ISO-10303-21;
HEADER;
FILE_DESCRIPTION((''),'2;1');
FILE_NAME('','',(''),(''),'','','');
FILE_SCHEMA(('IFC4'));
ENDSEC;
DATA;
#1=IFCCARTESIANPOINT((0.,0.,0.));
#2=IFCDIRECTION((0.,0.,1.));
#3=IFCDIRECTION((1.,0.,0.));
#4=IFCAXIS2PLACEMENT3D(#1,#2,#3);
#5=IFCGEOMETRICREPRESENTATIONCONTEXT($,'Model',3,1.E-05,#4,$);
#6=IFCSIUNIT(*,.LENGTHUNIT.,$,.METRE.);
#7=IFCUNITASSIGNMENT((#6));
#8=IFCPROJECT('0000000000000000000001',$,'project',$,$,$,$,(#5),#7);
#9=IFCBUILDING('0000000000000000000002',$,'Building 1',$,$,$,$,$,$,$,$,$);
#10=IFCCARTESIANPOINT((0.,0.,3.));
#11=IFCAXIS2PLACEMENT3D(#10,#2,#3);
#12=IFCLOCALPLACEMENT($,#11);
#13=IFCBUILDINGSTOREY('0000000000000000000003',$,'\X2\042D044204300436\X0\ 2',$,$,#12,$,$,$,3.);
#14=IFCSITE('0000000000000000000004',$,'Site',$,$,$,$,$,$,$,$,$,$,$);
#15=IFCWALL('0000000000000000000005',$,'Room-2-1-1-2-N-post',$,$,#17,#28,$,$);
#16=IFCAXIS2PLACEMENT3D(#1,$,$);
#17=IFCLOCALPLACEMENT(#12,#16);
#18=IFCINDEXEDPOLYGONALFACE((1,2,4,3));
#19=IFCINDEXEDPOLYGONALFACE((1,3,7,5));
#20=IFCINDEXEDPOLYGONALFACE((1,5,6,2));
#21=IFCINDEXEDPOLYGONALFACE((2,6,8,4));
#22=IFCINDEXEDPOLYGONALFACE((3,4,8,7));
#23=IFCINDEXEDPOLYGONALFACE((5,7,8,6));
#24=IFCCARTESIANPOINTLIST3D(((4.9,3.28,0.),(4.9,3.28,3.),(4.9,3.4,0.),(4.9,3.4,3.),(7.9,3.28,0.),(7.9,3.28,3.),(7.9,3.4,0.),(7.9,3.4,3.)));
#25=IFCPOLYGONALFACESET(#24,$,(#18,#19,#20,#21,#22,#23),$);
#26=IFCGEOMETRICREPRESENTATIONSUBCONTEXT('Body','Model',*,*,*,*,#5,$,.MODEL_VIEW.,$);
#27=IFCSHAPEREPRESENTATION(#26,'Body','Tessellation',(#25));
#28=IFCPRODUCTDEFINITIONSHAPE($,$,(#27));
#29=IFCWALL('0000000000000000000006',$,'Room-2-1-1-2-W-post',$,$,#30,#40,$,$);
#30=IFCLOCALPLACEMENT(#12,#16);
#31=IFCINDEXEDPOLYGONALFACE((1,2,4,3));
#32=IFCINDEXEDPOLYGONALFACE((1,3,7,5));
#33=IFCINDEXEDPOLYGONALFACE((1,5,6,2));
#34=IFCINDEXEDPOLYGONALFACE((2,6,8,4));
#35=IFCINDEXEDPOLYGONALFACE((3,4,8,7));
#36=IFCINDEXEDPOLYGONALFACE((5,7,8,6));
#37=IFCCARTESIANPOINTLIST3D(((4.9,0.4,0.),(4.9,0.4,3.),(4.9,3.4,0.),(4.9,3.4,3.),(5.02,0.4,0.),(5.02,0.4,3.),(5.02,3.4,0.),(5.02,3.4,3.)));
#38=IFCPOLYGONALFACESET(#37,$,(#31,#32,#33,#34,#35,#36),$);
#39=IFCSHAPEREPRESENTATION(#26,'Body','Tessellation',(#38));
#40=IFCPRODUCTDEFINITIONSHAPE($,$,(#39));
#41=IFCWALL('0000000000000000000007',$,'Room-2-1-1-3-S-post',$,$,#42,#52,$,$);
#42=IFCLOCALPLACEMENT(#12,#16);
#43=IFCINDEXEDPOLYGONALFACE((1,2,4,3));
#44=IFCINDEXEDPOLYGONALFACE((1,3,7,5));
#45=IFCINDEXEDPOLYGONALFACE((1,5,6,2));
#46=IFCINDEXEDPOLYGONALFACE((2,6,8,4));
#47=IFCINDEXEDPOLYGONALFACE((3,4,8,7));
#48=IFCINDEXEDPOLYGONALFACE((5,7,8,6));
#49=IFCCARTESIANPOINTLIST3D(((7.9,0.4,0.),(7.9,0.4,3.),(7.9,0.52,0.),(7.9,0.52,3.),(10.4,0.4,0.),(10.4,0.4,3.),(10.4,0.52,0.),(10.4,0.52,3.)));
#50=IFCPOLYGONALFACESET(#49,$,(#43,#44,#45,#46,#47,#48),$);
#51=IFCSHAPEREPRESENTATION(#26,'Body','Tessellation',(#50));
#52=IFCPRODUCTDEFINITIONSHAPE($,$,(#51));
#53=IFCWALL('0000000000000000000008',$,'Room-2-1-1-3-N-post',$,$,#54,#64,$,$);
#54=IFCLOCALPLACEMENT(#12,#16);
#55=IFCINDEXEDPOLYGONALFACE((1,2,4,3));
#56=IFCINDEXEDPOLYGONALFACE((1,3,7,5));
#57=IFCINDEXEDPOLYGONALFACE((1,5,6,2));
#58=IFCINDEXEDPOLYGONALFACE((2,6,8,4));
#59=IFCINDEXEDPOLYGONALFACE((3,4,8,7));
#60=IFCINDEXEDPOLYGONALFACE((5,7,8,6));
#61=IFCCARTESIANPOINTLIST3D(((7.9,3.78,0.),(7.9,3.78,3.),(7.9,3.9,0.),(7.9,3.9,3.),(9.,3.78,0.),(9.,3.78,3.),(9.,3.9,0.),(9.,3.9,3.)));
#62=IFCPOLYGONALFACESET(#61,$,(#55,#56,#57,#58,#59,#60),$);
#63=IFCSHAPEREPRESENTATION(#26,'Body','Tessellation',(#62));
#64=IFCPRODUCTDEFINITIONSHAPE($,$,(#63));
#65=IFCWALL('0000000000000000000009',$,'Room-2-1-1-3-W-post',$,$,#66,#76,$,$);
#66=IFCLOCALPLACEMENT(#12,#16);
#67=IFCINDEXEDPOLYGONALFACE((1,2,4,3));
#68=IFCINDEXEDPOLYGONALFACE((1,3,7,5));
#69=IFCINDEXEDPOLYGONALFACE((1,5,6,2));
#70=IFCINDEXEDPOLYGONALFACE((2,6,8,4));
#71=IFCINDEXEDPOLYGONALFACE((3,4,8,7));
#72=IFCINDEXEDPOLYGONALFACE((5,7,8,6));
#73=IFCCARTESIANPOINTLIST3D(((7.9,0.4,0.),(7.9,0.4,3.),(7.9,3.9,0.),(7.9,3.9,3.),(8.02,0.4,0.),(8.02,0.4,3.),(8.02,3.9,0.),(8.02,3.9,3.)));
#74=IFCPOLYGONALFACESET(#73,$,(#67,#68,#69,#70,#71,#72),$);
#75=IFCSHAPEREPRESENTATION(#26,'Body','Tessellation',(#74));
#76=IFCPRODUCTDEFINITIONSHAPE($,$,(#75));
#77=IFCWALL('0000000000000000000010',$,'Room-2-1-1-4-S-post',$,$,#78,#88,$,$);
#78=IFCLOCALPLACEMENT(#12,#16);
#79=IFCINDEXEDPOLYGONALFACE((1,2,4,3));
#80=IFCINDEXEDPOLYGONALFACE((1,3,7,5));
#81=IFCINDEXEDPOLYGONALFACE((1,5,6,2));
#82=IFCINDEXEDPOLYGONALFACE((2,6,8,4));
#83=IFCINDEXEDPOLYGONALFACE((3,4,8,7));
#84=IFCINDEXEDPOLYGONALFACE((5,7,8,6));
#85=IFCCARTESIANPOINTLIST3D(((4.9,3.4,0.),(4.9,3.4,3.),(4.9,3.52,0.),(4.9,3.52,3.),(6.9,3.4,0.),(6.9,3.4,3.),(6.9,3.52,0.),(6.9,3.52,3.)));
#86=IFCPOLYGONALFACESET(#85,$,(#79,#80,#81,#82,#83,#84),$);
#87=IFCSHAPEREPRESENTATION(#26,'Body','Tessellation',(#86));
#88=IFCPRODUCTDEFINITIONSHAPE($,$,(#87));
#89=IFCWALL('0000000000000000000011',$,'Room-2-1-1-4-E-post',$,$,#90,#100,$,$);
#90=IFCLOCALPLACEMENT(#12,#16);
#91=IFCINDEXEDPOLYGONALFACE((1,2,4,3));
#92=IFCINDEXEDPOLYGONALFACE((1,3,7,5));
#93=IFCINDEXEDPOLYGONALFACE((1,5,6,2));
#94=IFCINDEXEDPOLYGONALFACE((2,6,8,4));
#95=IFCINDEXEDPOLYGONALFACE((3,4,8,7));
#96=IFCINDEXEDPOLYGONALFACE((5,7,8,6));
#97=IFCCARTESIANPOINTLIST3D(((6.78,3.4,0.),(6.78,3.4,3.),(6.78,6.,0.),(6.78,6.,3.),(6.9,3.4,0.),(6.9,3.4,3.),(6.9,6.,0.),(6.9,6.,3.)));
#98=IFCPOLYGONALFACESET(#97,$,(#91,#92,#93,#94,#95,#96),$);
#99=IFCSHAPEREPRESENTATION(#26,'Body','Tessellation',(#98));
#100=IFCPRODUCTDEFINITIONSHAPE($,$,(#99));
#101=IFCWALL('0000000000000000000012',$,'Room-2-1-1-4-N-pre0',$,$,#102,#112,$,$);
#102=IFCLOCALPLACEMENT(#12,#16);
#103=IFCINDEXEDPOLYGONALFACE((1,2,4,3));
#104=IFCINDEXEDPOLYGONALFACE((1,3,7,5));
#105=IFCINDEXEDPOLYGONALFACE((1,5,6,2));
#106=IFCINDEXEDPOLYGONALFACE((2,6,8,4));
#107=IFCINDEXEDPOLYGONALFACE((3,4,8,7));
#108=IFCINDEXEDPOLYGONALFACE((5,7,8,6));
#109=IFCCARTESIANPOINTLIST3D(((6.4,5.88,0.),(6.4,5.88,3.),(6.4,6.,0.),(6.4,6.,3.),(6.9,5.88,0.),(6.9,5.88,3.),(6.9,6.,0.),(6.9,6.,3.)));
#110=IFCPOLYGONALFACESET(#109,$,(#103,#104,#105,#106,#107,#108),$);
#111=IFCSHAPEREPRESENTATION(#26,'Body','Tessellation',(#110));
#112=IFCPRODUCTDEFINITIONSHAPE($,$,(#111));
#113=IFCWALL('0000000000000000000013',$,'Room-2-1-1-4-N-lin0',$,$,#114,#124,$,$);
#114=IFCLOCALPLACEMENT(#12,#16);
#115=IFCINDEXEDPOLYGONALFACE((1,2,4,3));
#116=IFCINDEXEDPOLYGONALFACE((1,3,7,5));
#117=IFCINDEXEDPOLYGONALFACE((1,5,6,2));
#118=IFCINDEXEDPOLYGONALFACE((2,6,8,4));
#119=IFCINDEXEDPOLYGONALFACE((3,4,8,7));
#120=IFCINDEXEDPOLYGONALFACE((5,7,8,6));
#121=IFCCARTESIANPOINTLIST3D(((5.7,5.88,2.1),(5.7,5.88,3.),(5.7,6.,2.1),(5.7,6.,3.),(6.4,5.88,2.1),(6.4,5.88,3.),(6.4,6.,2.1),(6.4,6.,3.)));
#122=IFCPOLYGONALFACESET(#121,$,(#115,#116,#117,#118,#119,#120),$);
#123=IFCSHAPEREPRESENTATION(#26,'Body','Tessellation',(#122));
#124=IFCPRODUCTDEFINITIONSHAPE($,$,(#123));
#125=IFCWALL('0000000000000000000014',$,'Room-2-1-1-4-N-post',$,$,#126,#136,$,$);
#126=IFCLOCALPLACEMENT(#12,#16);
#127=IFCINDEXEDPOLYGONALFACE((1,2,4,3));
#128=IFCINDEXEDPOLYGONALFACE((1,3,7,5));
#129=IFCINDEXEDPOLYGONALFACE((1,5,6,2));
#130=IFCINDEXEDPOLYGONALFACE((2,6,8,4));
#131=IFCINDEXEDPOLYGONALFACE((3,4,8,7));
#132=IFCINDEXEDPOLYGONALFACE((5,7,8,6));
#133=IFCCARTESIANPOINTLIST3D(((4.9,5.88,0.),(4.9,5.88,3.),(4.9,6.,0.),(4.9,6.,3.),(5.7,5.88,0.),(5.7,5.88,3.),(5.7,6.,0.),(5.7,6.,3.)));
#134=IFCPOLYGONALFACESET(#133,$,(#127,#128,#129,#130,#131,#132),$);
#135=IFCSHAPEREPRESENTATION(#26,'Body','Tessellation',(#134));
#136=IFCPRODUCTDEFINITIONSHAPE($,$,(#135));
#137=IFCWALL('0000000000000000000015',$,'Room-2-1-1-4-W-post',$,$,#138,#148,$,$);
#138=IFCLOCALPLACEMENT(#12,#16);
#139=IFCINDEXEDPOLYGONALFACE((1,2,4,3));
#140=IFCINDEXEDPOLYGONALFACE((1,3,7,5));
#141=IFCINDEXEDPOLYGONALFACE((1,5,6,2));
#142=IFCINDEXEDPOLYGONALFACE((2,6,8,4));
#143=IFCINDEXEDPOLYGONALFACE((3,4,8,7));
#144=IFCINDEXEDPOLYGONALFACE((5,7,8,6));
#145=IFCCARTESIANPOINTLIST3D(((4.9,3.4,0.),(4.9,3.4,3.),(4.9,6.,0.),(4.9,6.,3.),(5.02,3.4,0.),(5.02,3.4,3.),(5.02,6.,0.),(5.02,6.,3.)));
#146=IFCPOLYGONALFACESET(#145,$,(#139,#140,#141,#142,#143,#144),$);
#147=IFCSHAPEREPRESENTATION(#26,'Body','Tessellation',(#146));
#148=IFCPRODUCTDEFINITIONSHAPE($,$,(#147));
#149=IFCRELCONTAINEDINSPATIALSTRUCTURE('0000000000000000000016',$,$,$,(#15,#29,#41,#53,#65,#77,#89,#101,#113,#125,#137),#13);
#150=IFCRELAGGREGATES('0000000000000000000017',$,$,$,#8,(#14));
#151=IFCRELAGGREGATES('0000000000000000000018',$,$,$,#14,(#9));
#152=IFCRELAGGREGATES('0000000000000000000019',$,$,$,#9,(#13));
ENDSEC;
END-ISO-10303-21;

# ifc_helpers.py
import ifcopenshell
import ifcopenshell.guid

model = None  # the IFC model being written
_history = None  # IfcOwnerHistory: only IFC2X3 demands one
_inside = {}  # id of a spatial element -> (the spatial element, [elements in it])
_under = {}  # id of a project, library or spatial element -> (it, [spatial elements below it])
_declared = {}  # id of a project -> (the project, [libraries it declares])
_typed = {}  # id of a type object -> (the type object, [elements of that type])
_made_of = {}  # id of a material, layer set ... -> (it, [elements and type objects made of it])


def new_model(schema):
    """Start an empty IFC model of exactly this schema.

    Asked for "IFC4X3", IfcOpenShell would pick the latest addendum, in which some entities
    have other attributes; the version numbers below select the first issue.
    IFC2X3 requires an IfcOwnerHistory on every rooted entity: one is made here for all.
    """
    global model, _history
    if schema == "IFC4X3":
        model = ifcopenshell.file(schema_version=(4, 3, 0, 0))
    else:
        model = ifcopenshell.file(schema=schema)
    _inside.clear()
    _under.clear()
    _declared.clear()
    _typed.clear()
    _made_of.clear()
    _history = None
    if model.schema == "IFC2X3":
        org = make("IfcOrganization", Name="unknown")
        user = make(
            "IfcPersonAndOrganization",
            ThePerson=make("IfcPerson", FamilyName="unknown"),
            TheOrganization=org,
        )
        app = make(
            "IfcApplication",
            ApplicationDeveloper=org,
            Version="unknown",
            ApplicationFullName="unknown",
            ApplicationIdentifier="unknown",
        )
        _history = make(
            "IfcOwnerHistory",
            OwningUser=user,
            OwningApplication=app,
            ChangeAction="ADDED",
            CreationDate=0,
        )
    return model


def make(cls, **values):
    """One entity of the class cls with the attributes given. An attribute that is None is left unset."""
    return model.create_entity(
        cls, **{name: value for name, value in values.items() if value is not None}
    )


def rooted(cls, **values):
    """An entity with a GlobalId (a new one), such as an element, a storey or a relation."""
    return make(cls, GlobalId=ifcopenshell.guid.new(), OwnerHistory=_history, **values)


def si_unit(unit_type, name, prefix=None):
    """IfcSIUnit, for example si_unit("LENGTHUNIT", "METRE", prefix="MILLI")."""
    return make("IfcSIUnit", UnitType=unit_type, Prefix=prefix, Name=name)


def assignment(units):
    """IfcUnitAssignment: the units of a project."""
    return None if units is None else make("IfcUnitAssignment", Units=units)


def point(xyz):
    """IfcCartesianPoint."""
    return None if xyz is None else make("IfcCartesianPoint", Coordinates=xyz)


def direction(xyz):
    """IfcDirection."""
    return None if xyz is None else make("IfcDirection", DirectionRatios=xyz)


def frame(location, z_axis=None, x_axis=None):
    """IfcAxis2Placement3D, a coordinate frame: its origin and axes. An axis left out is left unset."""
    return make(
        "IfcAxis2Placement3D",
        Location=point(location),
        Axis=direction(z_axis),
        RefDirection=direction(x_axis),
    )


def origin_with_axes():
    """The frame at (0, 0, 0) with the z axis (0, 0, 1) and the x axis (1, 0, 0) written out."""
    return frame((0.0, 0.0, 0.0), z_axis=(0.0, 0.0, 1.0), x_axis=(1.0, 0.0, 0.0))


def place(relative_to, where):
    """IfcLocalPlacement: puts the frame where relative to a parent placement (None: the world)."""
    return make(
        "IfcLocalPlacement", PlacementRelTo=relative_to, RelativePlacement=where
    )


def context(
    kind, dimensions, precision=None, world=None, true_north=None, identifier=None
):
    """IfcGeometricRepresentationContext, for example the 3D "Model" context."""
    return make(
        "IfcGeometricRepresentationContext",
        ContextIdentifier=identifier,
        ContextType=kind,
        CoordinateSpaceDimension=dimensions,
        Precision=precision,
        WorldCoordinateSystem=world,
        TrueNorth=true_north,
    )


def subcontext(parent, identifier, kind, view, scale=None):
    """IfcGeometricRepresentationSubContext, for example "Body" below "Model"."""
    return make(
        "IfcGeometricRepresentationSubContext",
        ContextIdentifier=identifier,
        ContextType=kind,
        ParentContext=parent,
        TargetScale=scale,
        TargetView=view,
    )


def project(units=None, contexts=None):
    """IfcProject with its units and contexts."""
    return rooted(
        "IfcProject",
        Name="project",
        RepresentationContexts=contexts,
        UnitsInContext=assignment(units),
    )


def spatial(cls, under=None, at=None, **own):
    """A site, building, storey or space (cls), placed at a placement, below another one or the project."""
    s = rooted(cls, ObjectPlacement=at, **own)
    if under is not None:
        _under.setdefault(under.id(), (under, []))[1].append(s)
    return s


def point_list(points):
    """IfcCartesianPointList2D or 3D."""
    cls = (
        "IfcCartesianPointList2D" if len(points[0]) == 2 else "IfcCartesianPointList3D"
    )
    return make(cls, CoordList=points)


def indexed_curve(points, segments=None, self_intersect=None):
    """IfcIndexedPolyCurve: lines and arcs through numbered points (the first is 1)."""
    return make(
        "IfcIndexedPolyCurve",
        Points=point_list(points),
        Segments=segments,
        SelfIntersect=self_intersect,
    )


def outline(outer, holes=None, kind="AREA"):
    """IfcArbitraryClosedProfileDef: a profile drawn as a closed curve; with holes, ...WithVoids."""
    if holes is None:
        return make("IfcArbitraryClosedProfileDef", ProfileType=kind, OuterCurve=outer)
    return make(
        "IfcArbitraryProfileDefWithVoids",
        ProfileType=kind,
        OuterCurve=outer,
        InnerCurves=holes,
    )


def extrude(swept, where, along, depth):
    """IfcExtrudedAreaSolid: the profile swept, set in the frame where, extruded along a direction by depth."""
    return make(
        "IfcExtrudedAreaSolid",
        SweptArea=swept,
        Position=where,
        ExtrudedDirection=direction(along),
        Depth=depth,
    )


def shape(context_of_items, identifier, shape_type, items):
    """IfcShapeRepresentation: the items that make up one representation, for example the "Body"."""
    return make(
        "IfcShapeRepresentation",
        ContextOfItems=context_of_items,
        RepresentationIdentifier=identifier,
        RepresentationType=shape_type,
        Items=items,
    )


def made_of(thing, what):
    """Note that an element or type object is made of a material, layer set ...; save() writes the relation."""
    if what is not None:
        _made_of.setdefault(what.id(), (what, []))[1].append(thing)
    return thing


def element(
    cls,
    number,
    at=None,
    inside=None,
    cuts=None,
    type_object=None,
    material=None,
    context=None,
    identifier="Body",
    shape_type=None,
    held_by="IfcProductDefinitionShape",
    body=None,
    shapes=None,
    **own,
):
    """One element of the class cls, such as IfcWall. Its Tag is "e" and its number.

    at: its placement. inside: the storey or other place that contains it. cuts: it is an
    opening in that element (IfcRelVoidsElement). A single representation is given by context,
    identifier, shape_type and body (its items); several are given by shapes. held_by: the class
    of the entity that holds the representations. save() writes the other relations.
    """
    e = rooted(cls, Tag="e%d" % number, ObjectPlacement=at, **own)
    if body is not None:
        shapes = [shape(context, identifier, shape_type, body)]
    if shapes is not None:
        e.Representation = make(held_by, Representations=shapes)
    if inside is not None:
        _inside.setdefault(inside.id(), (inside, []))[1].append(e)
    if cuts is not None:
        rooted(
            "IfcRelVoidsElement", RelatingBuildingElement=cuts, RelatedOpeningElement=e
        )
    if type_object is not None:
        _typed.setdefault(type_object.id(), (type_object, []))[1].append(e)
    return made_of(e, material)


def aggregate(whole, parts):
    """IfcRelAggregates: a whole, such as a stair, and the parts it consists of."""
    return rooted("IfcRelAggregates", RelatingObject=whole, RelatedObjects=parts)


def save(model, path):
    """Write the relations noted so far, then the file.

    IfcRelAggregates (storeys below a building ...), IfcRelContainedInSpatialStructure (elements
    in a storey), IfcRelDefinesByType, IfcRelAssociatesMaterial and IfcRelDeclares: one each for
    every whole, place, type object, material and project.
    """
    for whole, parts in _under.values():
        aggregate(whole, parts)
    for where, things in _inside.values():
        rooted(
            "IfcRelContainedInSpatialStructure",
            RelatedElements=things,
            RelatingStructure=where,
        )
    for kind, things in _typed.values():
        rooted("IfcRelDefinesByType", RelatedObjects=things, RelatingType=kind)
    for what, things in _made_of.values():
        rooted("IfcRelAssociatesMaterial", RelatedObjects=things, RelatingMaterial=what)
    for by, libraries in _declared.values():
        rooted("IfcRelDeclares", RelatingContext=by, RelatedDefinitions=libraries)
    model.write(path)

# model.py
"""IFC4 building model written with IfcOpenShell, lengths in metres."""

from ifc_helpers import new_model, si_unit, frame, origin_with_axes, place, context, subcontext, project, spatial, indexed_curve, outline, extrude, element, save


model = new_model("IFC4")

# Units and contexts
model_context = context("Model", 3, precision=1e-05, world=origin_with_axes())
body_context = subcontext(model_context, "Body", "Model", "MODEL_VIEW")
ifc_project = project(units=[si_unit("LENGTHUNIT", "METRE")], contexts=[model_context])

# Site, building, storey
site = spatial("IfcSite", under=ifc_project, Name="Site")
building = spatial("IfcBuilding", under=site, Name="Building 1")
storey_placement = place(None, frame((0.0, 0.0, 3.0), z_axis=(0.0, 0.0, 1.0), x_axis=(1.0, 0.0, 0.0)))
storey = spatial("IfcBuildingStorey", under=building, at=storey_placement, Name="Этаж 2", Elevation=3.0)

# Walls
for number, where, z_axis, x_axis, name in (
    (1, (7.9, 3.4, 0.0), (0.0, 0.0, 1.0), (-1.0, 0.0, 0.0), "Room-2-1-1-2-N-post"),
    (2, (4.9, 3.4, 0.0), (0.0, 0.0, 1.0), (0.0, -1.0, 0.0), "Room-2-1-1-2-W-post"),
):
    element("IfcWall", number, at=place(storey_placement, frame(where, z_axis=z_axis, x_axis=x_axis)), inside=storey, Name=name, context=body_context, shape_type="SweptSolid", body=[
        extrude(outline(indexed_curve([(0.0, 0.0), (0.0, 0.12), (3.0, 0.12), (3.0, 0.0), (0.0, 0.0)], self_intersect=False)), origin_with_axes(), (0.0, 0.0, 1.0), 3.0),
    ])
wall_1_placement = place(storey_placement, frame((7.9, 0.4, 0.0), z_axis=(0.0, 0.0, 1.0), x_axis=(1.0, 0.0, 0.0)))
element("IfcWall", 3, at=wall_1_placement, inside=storey, Name="Room-2-1-1-3-S-post", context=body_context, shape_type="SweptSolid", body=[
    extrude(outline(indexed_curve([(0.0, 0.0), (0.0, 0.12), (2.5, 0.12), (2.5, 0.0), (0.0, 0.0)], self_intersect=False)), origin_with_axes(), (0.0, 0.0, 1.0), 3.0),
])
wall_2_placement = place(storey_placement, frame((9.0, 3.9, 0.0), z_axis=(0.0, 0.0, 1.0), x_axis=(-1.0, 0.0, 0.0)))
element("IfcWall", 4, at=wall_2_placement, inside=storey, Name="Room-2-1-1-3-N-post", context=body_context, shape_type="SweptSolid", body=[
    extrude(outline(indexed_curve([(0.0, 0.0), (0.0, 0.12), (1.1, 0.12), (1.1, 0.0), (0.0, 0.0)], self_intersect=False)), origin_with_axes(), (0.0, 0.0, 1.0), 3.0),
])
wall_3_placement = place(storey_placement, frame((7.9, 3.9, 0.0), z_axis=(0.0, 0.0, 1.0), x_axis=(0.0, -1.0, 0.0)))
element("IfcWall", 5, at=wall_3_placement, inside=storey, Name="Room-2-1-1-3-W-post", context=body_context, shape_type="SweptSolid", body=[
    extrude(outline(indexed_curve([(0.0, 0.0), (0.0, 0.12), (3.5, 0.12), (3.5, 0.0), (0.0, 0.0)], self_intersect=False)), origin_with_axes(), (0.0, 0.0, 1.0), 3.0),
])
wall_4_placement = place(storey_placement, frame((4.9, 3.4, 0.0), z_axis=(0.0, 0.0, 1.0), x_axis=(1.0, 0.0, 0.0)))
element("IfcWall", 6, at=wall_4_placement, inside=storey, Name="Room-2-1-1-4-S-post", context=body_context, shape_type="SweptSolid", body=[
    extrude(outline(indexed_curve([(0.0, 0.0), (0.0, 0.12), (2.0, 0.12), (2.0, 0.0), (0.0, 0.0)], self_intersect=False)), origin_with_axes(), (0.0, 0.0, 1.0), 3.0),
])
wall_5_placement = place(storey_placement, frame((6.9, 3.4, 0.0), z_axis=(0.0, 0.0, 1.0), x_axis=(0.0, 1.0, 0.0)))
element("IfcWall", 7, at=wall_5_placement, inside=storey, Name="Room-2-1-1-4-E-post", context=body_context, shape_type="SweptSolid", body=[
    extrude(outline(indexed_curve([(0.0, 0.0), (0.0, 0.12), (2.6, 0.12), (2.6, 0.0), (0.0, 0.0)], self_intersect=False)), origin_with_axes(), (0.0, 0.0, 1.0), 3.0),
])
wall_6_placement = place(storey_placement, frame((6.9, 6.0, 0.0), z_axis=(0.0, 0.0, 1.0), x_axis=(-1.0, 0.0, 0.0)))
element("IfcWall", 8, at=wall_6_placement, inside=storey, Name="Room-2-1-1-4-N-pre0", context=body_context, shape_type="SweptSolid", body=[
    extrude(outline(indexed_curve([(0.0, 0.0), (0.0, 0.12), (0.5, 0.12), (0.5, 0.0), (0.0, 0.0)], self_intersect=False)), origin_with_axes(), (0.0, 0.0, 1.0), 3.0),
])
wall_7_placement = place(storey_placement, frame((6.4, 6.0, 2.1), z_axis=(0.0, 0.0, 1.0), x_axis=(-1.0, 0.0, 0.0)))
element("IfcWall", 9, at=wall_7_placement, inside=storey, Name="Room-2-1-1-4-N-lin0", context=body_context, shape_type="SweptSolid", body=[
    extrude(outline(indexed_curve([(0.0, 0.0), (0.0, 0.12), (0.7, 0.12), (0.7, 0.0), (0.0, 0.0)], self_intersect=False)), origin_with_axes(), (0.0, 0.0, 1.0), 0.9),
])
wall_8_placement = place(storey_placement, frame((5.7, 6.0, 0.0), z_axis=(0.0, 0.0, 1.0), x_axis=(-1.0, 0.0, 0.0)))
element("IfcWall", 10, at=wall_8_placement, inside=storey, Name="Room-2-1-1-4-N-post", context=body_context, shape_type="SweptSolid", body=[
    extrude(outline(indexed_curve([(0.0, 0.0), (0.0, 0.12), (0.8, 0.12), (0.8, 0.0), (0.0, 0.0)], self_intersect=False)), origin_with_axes(), (0.0, 0.0, 1.0), 3.0),
])
wall_9_placement = place(storey_placement, frame((4.9, 6.0, 0.0), z_axis=(0.0, 0.0, 1.0), x_axis=(0.0, -1.0, 0.0)))
element("IfcWall", 11, at=wall_9_placement, inside=storey, Name="Room-2-1-1-4-W-post", context=body_context, shape_type="SweptSolid", body=[
    extrude(outline(indexed_curve([(0.0, 0.0), (0.0, 0.12), (2.6, 0.12), (2.6, 0.0), (0.0, 0.0)], self_intersect=False)), origin_with_axes(), (0.0, 0.0, 1.0), 3.0),
])

save(model, "model.ifc")
